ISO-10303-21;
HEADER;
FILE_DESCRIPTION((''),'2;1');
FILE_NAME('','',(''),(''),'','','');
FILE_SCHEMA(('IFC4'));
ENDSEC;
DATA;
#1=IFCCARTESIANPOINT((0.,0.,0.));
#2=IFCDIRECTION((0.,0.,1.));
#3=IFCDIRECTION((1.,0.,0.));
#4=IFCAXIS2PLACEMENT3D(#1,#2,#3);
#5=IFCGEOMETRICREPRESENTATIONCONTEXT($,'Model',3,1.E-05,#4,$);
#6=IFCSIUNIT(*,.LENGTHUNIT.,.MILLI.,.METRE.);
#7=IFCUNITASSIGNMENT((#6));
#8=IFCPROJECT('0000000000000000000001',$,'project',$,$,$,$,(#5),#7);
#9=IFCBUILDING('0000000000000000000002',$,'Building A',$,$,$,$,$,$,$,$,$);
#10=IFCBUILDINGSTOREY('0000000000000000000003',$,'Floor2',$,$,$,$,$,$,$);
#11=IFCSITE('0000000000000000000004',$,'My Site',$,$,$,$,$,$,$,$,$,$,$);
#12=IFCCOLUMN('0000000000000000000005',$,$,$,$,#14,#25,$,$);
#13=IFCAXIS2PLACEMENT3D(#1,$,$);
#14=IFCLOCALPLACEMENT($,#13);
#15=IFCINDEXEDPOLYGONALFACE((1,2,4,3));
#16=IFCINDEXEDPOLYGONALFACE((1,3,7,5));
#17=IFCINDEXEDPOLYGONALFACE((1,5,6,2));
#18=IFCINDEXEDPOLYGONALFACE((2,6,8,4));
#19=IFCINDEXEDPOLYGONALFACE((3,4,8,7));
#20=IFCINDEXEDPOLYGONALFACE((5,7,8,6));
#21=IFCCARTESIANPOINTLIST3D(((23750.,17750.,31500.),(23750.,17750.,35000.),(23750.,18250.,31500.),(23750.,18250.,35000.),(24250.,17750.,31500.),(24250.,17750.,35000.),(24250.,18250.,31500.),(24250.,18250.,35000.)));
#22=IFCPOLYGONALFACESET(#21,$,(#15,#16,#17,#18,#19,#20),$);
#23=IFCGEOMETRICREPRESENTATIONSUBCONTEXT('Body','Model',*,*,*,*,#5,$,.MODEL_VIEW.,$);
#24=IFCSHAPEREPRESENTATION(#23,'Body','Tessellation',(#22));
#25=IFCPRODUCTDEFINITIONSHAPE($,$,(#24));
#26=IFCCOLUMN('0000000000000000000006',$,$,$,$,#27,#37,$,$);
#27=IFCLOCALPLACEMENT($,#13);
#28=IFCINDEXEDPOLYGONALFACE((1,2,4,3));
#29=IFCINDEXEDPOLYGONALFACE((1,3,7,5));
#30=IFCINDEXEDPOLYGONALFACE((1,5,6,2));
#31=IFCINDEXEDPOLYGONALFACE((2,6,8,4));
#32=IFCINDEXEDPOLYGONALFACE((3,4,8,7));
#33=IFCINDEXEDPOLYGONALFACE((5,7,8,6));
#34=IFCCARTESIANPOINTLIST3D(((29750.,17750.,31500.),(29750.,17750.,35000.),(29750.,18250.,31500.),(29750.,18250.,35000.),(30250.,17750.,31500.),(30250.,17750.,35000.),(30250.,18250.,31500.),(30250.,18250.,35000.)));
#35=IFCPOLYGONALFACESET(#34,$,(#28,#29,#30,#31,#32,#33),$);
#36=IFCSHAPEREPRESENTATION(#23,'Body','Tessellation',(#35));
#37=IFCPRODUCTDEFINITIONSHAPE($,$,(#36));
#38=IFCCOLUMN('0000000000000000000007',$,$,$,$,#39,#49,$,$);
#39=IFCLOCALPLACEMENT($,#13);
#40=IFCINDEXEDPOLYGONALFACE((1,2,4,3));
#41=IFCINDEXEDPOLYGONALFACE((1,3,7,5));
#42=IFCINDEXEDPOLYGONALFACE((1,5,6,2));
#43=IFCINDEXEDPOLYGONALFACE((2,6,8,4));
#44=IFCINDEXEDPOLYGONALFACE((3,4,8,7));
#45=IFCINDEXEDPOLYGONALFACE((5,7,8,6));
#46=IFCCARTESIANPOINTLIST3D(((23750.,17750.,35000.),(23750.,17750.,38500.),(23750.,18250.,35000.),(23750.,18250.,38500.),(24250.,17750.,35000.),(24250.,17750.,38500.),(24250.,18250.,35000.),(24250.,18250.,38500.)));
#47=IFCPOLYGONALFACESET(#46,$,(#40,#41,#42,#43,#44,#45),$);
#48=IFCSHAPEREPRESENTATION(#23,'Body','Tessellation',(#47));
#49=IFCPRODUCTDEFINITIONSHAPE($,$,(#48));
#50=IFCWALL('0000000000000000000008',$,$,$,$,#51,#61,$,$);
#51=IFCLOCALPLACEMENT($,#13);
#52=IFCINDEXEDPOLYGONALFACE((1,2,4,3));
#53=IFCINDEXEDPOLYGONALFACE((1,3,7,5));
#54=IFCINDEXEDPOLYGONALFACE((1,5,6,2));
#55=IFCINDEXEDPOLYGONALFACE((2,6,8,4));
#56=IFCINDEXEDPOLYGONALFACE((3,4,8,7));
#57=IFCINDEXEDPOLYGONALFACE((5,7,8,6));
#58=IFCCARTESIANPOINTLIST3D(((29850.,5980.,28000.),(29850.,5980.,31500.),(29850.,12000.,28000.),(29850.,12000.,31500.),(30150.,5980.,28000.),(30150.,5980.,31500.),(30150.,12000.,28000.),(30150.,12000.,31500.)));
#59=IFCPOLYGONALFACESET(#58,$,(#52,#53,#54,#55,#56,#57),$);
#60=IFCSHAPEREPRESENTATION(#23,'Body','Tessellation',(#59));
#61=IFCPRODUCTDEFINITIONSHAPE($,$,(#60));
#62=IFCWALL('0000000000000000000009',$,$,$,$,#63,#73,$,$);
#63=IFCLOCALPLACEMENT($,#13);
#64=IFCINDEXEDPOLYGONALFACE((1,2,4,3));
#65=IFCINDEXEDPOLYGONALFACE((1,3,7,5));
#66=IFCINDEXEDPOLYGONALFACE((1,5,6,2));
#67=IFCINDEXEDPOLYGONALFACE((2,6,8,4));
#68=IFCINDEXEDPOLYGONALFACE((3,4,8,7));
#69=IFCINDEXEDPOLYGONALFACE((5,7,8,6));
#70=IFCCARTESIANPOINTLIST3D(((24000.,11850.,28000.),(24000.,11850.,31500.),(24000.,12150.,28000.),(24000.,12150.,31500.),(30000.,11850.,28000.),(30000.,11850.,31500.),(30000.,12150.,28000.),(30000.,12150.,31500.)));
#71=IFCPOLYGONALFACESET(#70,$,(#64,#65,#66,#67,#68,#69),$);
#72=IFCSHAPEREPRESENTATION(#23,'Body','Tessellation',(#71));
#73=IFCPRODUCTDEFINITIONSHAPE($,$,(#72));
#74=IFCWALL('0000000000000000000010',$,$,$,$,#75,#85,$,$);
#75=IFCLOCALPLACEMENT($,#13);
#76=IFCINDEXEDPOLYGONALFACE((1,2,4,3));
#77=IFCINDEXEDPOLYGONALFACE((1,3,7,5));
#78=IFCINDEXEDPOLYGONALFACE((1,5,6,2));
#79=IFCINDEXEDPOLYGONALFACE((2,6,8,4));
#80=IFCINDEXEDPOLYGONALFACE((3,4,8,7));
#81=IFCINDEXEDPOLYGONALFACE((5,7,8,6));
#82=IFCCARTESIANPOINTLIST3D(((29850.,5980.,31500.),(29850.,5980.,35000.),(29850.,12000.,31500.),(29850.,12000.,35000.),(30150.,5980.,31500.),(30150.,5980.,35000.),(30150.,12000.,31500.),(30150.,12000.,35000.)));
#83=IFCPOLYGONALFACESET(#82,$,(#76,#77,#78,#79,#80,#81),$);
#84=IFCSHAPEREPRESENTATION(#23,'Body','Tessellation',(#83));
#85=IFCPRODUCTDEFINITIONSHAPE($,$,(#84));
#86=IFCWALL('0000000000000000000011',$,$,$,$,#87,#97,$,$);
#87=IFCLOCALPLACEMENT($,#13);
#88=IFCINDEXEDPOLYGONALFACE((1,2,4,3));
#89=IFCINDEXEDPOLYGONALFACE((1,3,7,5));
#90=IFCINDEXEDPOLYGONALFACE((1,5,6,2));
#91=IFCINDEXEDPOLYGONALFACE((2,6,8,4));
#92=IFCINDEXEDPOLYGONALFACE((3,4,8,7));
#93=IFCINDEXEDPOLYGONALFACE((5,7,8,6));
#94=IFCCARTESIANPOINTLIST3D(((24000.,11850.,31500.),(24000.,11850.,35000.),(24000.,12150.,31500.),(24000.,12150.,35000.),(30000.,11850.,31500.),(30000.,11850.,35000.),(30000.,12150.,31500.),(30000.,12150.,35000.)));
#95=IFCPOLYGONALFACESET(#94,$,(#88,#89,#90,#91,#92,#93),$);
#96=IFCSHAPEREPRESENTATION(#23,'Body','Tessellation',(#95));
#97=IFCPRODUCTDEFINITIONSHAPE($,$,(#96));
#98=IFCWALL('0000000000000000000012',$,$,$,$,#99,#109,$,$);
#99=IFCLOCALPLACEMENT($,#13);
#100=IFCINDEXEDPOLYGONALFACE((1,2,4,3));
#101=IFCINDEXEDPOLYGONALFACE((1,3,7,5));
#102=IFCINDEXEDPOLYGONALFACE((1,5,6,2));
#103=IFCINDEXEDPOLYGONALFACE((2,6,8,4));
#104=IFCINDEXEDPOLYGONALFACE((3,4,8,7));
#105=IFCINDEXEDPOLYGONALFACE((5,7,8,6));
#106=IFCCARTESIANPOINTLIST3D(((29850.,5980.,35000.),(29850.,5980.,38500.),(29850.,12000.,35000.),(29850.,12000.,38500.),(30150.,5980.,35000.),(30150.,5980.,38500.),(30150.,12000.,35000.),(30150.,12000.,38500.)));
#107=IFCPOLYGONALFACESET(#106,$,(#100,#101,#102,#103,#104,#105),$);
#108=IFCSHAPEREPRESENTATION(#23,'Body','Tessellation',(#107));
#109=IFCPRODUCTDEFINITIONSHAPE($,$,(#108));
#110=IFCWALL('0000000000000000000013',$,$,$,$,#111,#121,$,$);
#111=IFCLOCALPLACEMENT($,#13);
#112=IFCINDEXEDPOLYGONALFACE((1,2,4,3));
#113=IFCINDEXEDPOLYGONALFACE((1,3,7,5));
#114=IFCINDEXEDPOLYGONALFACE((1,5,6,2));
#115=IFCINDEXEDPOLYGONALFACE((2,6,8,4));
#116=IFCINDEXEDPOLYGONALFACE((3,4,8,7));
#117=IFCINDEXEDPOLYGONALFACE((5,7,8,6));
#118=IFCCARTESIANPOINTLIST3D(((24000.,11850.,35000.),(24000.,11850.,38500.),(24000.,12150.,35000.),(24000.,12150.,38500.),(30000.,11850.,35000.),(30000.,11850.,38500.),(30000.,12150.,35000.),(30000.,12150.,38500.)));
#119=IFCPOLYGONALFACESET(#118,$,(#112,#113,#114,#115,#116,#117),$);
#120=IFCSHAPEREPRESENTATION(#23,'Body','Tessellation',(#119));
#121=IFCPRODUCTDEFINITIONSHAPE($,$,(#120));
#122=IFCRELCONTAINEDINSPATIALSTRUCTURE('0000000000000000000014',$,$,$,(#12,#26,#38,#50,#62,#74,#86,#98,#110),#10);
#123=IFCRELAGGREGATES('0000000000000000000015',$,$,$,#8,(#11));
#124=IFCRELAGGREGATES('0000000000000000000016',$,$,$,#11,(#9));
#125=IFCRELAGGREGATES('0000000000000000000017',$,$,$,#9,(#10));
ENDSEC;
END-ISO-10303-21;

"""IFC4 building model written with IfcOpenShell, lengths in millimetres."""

from ifc_helpers import new_model, si_unit, frame, origin_with_axes, place, context, subcontext, project, spatial, line, indexed_curve, outline, extrude, element, save


model = new_model("IFC4")

# Units and contexts
model_context = context("Model", 3, precision=1e-05, world=origin_with_axes())
body_context = subcontext(model_context, "Body", "Model", "MODEL_VIEW")
ifc_project = project(units=[si_unit("LENGTHUNIT", "METRE", prefix="MILLI")], contexts=[model_context])

# Site, building, storey
site = spatial("IfcSite", under=ifc_project, Name="My Site")
building = spatial("IfcBuilding", under=site, Name="Building A")
storey = spatial("IfcBuildingStorey", under=building, Name="Floor2")

# Columns
for number, where, z_axis, x_axis in (
    (1, (24000.0, 18000.0, 31500.0), (0.0, 0.0, 1.0), (1.0, 0.0, 0.0)),
    (2, (30000.0, 18000.0, 31500.0), (0.0, 0.0, 1.0), (1.0, 0.0, 0.0)),
    (3, (24000.0, 18000.0, 35000.0), (0.0, 0.0, 1.0), (1.0, 0.0, 0.0)),
):
    element("IfcColumn", number, at=place(None, frame(where, z_axis=z_axis, x_axis=x_axis)), inside=storey, context=body_context, shape_type="SweptSolid", body=[
        extrude(outline(indexed_curve([(-250.0, -250.0), (250.0, -250.0), (250.0, 250.0), (-250.0, 250.0)], segments=[line(1, 2, 3, 4, 1)])), origin_with_axes(), (0.0, 0.0, 1.0), 3500.0),
    ])

# Walls
wall_1_placement = place(None, frame((29850.0, 12000.0, 28000.0), z_axis=(0.0, 0.0, 1.0), x_axis=(0.0, -1.0, 0.0)))
element("IfcWall", 4, at=wall_1_placement, inside=storey, context=body_context, shape_type="SweptSolid", body=[
    extrude(outline(indexed_curve([(0.0, 0.0), (0.0, 300.0), (6020.0, 300.0), (6020.0, 0.0), (0.0, 0.0)], self_intersect=False)), origin_with_axes(), (0.0, 0.0, 1.0), 3500.0),
])
wall_2_placement = place(None, frame((24000.0, 11850.0, 28000.0), z_axis=(0.0, 0.0, 1.0), x_axis=(1.0, 0.0, 0.0)))
element("IfcWall", 5, at=wall_2_placement, inside=storey, context=body_context, shape_type="SweptSolid", body=[
    extrude(outline(indexed_curve([(0.0, 0.0), (0.0, 300.0), (6000.0, 300.0), (6000.0, 0.0), (0.0, 0.0)], self_intersect=False)), origin_with_axes(), (0.0, 0.0, 1.0), 3500.0),
])
wall_3_placement = place(None, frame((29850.0, 12000.0, 31500.0), z_axis=(0.0, 0.0, 1.0), x_axis=(0.0, -1.0, 0.0)))
element("IfcWall", 6, at=wall_3_placement, inside=storey, context=body_context, shape_type="SweptSolid", body=[
    extrude(outline(indexed_curve([(0.0, 0.0), (0.0, 300.0), (6020.0, 300.0), (6020.0, 0.0), (0.0, 0.0)], self_intersect=False)), origin_with_axes(), (0.0, 0.0, 1.0), 3500.0),
])
wall_4_placement = place(None, frame((24000.0, 11850.0, 31500.0), z_axis=(0.0, 0.0, 1.0), x_axis=(1.0, 0.0, 0.0)))
element("IfcWall", 7, at=wall_4_placement, inside=storey, context=body_context, shape_type="SweptSolid", body=[
    extrude(outline(indexed_curve([(0.0, 0.0), (0.0, 300.0), (6000.0, 300.0), (6000.0, 0.0), (0.0, 0.0)], self_intersect=False)), origin_with_axes(), (0.0, 0.0, 1.0), 3500.0),
])
wall_5_placement = place(None, frame((29850.0, 12000.0, 35000.0), z_axis=(0.0, 0.0, 1.0), x_axis=(0.0, -1.0, 0.0)))
element("IfcWall", 8, at=wall_5_placement, inside=storey, context=body_context, shape_type="SweptSolid", body=[
    extrude(outline(indexed_curve([(0.0, 0.0), (0.0, 300.0), (6020.0, 300.0), (6020.0, 0.0), (0.0, 0.0)], self_intersect=False)), origin_with_axes(), (0.0, 0.0, 1.0), 3500.0),
])
wall_6_placement = place(None, frame((24000.0, 11850.0, 35000.0), z_axis=(0.0, 0.0, 1.0), x_axis=(1.0, 0.0, 0.0)))
element("IfcWall", 9, at=wall_6_placement, inside=storey, context=body_context, shape_type="SweptSolid", body=[
    extrude(outline(indexed_curve([(0.0, 0.0), (0.0, 300.0), (6000.0, 300.0), (6000.0, 0.0), (0.0, 0.0)], self_intersect=False)), origin_with_axes(), (0.0, 0.0, 1.0), 3500.0),
])

save(model, "model.ifc")
